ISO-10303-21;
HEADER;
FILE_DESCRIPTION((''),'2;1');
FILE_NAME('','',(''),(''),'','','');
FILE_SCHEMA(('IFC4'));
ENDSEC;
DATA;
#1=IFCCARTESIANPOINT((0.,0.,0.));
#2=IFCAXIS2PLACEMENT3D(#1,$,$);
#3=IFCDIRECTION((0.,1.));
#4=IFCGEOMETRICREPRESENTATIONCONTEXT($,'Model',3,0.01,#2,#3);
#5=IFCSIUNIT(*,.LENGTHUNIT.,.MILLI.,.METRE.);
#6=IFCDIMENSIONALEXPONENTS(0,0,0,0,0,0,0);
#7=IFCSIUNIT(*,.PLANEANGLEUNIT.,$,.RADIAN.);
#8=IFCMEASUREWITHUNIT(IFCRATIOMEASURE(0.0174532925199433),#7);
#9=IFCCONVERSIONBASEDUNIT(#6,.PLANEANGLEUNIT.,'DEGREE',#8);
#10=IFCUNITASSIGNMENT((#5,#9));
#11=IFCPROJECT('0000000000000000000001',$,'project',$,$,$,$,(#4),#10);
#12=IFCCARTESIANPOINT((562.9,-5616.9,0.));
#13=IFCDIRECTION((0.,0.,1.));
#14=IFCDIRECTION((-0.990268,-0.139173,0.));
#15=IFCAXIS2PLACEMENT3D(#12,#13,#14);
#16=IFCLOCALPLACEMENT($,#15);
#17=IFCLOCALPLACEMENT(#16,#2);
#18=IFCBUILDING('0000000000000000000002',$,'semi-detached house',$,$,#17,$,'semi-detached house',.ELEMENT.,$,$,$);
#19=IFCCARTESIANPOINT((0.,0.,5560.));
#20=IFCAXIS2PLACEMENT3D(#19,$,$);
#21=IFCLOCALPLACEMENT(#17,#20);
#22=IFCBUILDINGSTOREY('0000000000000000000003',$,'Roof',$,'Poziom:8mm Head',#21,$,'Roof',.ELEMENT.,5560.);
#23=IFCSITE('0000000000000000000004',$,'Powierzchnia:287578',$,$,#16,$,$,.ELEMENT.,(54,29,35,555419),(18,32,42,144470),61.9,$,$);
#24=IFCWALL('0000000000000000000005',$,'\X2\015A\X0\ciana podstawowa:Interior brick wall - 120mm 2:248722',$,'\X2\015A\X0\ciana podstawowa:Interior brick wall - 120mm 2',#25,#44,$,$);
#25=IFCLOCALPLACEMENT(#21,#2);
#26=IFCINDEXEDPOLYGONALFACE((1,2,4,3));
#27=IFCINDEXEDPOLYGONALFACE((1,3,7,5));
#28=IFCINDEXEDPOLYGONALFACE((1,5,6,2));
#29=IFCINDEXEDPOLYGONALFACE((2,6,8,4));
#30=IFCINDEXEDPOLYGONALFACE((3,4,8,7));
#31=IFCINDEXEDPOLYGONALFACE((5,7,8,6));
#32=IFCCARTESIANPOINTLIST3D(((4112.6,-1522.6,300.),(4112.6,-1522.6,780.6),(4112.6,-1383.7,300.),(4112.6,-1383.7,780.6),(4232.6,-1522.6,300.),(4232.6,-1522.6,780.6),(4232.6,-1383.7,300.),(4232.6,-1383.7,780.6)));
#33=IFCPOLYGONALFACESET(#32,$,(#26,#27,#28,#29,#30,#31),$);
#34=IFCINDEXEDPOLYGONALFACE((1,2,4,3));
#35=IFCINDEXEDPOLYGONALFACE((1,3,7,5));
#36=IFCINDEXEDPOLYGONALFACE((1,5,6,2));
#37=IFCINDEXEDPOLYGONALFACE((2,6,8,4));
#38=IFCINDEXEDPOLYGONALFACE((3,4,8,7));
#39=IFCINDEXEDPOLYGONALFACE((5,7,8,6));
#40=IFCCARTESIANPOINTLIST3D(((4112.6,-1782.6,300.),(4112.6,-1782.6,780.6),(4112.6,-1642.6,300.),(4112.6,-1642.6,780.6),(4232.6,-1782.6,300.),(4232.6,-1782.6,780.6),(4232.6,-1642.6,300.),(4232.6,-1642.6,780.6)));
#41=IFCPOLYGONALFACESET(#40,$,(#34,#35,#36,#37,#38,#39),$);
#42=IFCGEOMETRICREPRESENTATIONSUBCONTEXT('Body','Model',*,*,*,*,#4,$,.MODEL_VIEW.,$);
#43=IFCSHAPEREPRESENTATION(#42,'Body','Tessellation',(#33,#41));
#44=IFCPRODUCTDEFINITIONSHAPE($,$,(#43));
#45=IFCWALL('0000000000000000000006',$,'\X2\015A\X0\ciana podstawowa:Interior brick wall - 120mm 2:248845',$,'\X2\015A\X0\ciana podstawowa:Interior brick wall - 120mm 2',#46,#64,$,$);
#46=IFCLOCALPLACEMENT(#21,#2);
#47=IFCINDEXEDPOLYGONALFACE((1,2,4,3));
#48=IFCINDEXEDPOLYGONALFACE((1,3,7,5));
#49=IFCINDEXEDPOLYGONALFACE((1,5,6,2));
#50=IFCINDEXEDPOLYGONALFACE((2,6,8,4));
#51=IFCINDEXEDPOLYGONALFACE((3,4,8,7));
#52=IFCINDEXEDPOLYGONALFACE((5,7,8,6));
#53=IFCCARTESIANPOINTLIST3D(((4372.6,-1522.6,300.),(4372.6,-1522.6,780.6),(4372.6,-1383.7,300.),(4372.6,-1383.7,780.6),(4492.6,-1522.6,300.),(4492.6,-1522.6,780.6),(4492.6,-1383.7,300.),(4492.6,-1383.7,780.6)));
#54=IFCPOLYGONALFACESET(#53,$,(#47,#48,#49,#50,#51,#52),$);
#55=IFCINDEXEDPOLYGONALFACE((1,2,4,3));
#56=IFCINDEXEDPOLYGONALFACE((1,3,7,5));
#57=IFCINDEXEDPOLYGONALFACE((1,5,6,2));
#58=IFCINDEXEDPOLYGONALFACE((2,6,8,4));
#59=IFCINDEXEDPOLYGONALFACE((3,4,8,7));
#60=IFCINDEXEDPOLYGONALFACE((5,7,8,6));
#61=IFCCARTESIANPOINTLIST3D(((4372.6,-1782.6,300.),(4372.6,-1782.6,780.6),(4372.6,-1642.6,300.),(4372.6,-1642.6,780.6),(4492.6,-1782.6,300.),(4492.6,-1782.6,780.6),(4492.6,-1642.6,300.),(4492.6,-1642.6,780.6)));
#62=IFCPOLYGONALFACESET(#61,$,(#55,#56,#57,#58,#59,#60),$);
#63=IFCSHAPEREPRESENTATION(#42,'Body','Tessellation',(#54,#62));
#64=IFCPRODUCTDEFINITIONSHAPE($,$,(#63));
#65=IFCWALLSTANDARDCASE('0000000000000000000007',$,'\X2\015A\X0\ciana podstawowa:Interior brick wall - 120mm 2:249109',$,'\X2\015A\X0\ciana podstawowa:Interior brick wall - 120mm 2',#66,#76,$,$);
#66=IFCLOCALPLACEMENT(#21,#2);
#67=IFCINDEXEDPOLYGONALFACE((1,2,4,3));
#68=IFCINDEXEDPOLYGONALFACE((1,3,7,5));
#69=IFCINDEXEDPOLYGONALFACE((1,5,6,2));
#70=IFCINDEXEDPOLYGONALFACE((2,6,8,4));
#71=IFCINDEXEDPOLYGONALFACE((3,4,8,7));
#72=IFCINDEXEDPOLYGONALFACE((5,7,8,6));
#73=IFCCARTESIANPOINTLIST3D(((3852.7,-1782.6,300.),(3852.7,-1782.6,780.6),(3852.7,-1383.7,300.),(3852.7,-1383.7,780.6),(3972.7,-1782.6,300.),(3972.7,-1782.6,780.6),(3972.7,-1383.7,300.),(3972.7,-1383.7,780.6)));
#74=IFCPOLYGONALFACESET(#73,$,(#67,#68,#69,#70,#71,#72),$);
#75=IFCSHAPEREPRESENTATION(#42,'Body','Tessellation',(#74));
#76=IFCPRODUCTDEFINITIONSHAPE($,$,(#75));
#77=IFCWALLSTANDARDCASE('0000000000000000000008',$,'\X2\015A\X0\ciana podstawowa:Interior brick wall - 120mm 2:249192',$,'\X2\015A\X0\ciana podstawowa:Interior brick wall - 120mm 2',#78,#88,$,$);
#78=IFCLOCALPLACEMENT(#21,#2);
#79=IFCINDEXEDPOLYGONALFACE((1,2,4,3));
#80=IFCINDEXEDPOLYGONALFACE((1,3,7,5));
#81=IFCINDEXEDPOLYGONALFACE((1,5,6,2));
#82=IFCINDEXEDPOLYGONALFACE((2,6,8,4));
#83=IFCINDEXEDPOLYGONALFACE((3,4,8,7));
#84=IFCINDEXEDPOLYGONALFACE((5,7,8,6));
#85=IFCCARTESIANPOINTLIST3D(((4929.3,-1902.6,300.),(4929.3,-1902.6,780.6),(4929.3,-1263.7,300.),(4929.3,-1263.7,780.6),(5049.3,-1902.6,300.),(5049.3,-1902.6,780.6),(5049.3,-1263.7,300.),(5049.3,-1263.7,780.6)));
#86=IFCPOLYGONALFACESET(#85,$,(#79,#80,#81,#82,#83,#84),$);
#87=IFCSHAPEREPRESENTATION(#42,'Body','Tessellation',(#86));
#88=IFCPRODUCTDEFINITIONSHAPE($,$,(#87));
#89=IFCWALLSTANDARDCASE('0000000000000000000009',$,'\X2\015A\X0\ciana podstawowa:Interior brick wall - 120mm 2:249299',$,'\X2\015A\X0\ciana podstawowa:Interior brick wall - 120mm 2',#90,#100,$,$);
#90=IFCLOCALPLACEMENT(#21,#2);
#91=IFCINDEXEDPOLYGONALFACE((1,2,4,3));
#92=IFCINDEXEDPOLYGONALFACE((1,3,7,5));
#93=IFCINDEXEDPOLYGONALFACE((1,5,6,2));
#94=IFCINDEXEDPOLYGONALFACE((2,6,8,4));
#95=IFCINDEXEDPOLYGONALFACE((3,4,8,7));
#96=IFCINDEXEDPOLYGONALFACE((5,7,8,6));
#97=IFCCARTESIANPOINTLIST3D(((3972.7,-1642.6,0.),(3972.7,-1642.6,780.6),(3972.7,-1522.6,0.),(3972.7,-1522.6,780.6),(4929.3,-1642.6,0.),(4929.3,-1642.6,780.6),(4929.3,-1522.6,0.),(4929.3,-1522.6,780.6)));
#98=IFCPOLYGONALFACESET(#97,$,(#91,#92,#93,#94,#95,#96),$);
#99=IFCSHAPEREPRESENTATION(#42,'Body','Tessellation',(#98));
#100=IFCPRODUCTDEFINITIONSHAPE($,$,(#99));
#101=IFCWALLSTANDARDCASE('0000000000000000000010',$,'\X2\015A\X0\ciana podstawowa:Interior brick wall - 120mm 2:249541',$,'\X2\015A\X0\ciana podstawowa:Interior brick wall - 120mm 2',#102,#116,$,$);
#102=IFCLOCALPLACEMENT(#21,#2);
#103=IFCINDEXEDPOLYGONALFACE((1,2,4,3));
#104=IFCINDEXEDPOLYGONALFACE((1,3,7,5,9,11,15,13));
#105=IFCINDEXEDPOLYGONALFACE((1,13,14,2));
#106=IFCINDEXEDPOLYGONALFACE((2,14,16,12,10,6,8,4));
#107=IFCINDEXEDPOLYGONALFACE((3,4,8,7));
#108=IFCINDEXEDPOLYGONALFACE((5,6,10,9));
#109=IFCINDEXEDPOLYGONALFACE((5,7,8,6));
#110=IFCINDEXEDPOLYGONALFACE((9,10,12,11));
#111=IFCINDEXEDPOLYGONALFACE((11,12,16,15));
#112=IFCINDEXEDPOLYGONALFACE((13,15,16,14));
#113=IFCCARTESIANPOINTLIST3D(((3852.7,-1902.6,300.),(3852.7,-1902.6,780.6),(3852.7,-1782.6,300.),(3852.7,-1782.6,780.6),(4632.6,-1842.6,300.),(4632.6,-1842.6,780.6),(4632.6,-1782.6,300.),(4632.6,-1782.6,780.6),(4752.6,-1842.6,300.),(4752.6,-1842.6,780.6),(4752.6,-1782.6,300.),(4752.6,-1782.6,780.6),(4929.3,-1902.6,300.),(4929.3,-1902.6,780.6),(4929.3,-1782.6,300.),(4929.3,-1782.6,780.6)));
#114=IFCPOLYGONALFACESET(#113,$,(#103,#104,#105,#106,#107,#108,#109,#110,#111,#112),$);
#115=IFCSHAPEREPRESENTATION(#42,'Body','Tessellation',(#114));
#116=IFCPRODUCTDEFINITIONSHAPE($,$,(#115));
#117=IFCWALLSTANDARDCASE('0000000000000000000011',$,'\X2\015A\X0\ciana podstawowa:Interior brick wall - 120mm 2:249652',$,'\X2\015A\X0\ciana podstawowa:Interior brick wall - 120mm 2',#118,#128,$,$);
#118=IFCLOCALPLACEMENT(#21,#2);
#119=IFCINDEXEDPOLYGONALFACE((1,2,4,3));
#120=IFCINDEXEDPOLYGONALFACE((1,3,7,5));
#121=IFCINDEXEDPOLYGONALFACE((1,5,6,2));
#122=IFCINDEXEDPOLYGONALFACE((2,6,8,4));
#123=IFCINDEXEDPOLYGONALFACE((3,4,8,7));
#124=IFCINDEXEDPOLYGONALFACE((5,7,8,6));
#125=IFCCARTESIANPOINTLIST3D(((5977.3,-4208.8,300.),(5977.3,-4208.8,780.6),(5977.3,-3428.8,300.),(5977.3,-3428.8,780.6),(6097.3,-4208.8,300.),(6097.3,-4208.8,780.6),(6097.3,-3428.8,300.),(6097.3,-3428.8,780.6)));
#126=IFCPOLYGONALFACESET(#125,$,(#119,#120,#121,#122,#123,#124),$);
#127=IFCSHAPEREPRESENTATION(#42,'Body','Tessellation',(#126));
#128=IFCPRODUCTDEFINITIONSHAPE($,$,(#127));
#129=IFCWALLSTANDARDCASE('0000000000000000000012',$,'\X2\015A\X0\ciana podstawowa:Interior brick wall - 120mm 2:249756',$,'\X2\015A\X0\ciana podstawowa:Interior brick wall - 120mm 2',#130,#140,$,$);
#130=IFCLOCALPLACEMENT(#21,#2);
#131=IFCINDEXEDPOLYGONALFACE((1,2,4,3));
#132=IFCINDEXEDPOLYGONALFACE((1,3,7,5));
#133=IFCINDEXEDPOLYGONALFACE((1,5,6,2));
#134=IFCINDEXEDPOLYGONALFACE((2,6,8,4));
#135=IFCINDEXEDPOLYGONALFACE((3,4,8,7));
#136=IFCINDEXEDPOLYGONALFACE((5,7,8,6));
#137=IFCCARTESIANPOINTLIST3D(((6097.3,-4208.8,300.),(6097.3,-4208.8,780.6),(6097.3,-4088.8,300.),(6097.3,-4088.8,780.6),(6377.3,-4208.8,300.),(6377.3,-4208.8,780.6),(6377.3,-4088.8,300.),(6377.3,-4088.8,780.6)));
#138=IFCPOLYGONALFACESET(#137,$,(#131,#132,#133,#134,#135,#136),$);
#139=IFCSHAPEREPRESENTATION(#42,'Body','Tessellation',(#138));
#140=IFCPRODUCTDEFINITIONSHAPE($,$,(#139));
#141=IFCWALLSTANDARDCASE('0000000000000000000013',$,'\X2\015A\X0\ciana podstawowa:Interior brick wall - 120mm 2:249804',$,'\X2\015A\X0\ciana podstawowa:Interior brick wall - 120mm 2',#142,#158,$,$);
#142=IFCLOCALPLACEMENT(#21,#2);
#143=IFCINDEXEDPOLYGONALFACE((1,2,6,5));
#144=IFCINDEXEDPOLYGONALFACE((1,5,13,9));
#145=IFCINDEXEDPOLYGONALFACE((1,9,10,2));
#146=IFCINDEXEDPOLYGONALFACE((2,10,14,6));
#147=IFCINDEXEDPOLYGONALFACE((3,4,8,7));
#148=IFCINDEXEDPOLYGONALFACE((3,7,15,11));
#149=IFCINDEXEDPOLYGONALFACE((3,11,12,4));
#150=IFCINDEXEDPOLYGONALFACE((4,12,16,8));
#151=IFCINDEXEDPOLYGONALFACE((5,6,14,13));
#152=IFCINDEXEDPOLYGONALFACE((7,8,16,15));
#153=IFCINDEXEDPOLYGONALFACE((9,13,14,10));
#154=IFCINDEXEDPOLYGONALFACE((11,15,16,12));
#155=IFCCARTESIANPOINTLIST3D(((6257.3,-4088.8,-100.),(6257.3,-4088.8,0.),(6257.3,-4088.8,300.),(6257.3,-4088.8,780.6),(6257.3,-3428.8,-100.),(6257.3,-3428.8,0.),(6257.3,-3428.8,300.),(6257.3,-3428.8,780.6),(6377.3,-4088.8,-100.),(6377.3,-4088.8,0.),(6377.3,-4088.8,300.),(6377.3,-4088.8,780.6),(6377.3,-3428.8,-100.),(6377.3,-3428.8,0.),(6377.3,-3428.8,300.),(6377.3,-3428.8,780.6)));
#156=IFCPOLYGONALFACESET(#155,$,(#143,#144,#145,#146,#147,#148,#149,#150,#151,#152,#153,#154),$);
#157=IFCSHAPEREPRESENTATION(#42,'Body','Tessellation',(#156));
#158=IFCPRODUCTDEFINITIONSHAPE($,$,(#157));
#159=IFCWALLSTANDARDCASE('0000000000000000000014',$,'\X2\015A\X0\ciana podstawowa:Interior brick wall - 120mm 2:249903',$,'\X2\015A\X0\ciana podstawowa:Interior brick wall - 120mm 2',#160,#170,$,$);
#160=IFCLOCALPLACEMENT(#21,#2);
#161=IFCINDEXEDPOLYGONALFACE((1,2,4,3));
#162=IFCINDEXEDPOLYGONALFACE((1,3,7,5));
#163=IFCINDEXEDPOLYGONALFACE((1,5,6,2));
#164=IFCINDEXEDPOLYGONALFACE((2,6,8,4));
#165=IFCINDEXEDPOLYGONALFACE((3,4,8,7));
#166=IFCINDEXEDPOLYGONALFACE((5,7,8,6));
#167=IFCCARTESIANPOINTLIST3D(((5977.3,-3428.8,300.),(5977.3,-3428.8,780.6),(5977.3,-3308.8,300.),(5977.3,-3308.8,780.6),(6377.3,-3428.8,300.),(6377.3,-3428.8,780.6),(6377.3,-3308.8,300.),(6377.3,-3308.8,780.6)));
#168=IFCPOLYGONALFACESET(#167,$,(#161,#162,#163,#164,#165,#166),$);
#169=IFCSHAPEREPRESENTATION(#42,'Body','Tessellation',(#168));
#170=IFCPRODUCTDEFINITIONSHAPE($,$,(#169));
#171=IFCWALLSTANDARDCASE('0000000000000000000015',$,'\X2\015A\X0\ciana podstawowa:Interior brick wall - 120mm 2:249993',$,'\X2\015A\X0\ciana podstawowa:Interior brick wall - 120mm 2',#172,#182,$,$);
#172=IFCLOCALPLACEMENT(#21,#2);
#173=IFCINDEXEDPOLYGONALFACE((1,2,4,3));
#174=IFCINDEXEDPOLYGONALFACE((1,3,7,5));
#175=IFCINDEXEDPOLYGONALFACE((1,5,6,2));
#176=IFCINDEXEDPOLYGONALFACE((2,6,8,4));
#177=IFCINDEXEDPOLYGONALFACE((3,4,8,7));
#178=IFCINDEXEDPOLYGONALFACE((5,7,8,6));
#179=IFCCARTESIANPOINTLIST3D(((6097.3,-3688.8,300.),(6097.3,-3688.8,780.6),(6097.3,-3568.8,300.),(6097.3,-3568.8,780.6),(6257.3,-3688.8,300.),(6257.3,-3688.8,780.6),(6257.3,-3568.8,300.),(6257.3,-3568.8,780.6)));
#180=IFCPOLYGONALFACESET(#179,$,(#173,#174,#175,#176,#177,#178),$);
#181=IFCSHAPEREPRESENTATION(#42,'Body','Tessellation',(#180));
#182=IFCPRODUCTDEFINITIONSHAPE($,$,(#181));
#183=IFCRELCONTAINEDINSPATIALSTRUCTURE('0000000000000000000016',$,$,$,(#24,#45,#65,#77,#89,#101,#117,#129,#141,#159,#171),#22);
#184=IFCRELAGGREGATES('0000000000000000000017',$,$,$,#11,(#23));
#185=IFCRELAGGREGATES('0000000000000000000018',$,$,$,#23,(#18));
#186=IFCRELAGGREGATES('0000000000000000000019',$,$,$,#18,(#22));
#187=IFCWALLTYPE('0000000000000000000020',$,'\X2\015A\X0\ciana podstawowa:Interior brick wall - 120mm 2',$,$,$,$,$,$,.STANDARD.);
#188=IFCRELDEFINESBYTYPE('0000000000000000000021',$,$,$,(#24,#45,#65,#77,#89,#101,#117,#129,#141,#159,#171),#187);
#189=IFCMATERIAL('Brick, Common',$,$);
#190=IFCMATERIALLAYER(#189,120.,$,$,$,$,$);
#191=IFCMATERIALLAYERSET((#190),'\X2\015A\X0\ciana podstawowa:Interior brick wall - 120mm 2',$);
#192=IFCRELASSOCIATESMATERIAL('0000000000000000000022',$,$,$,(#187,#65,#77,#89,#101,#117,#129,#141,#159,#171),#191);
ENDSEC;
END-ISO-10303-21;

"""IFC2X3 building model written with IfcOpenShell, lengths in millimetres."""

from ifc_helpers import new_model, entity, si_unit, converted_unit, direction, frame, frame_2d, origin, place, context, subcontext, project, spatial, polyline, rectangle, extrude, clip, bounded_halfspace, material, layer, layer_set, layer_usage, type_object, element, save


model = new_model("IFC2X3")

# Units and contexts
model_context = context("Model", 3, precision=0.01, world=origin(), true_north=direction((0.0, 1.0)))
body_context = subcontext(model_context, "Body", "Model", "MODEL_VIEW")
ifc_project = project(units=[si_unit("LENGTHUNIT", "METRE", prefix="MILLI"), converted_unit("PLANEANGLEUNIT", "DEGREE", entity("IfcRatioMeasure", 0.0174532925199433), si_unit("PLANEANGLEUNIT", "RADIAN"), dimensions=[0, 0, 0, 0, 0, 0, 0])], contexts=[model_context])

# Site, building, storey
site_placement = place(None, frame((562.9, -5616.9, 0.0), z_axis=(0.0, 0.0, 1.0), x_axis=(-0.990268, -0.139173, 0.0)))
site = spatial("IfcSite", under=ifc_project, at=site_placement, Name="Powierzchnia:287578", CompositionType="ELEMENT", RefLatitude=(54, 29, 35, 555419), RefLongitude=(18, 32, 42, 144470), RefElevation=61.9)
building_placement = place(site_placement, origin())
building = spatial("IfcBuilding", under=site, at=building_placement, Name="semi-detached house", LongName="semi-detached house", CompositionType="ELEMENT")
storey_placement = place(building_placement, frame((0.0, 0.0, 5560.0)))
storey = spatial("IfcBuildingStorey", under=building, at=storey_placement, Name="Roof", ObjectType="Poziom:8mm Head", LongName="Roof", CompositionType="ELEMENT", Elevation=5560.0)

# Walls
ifc_material = material(Name="Brick, Common")
ifc_layer = layer(ifc_material, 120.0)
ifc_layer_set = layer_set([ifc_layer], Name="Ściana podstawowa:Interior brick wall - 120mm 2")
wall_type = type_object("IfcWallType", Name="Ściana podstawowa:Interior brick wall - 120mm 2", PredefinedType="STANDARD", material=ifc_layer_set)
wall_1_placement = place(storey_placement, frame((4172.6, -1383.7, 300.0), z_axis=(0.0, 0.0, 1.0), x_axis=(0.0, -1.0, 0.0)))
element("IfcWall", 1, at=wall_1_placement, inside=storey, type_object=wall_type, Name="Ściana podstawowa:Interior brick wall - 120mm 2:248722", ObjectType="Ściana podstawowa:Interior brick wall - 120mm 2", context=body_context, shape_type="SweptSolid", body=[
    extrude(rectangle(XDim=120.0, YDim=138.9, at=frame_2d((0.0, 0.0), x_axis=(1.0, 0.0))), frame((69.5, 0.0, 0.0), z_axis=(0.0, 0.0, 1.0), x_axis=(0.0, 1.0, 0.0)), (0.0, 0.0, 1.0), 480.6),
    extrude(rectangle(XDim=120.0, YDim=140.0, at=frame_2d((0.0, -23.0), x_axis=(1.0, 0.0))), frame((305.9, 0.0, 0.0), z_axis=(0.0, 0.0, 1.0), x_axis=(0.0, 1.0, 0.0)), (0.0, 0.0, 1.0), 480.6),
])
wall_2_placement = place(storey_placement, frame((4432.6, -1383.7, 300.0), z_axis=(0.0, 0.0, 1.0), x_axis=(0.0, -1.0, 0.0)))
element("IfcWall", 2, at=wall_2_placement, inside=storey, type_object=wall_type, Name="Ściana podstawowa:Interior brick wall - 120mm 2:248845", ObjectType="Ściana podstawowa:Interior brick wall - 120mm 2", context=body_context, shape_type="SweptSolid", body=[
    extrude(rectangle(XDim=120.0, YDim=138.9, at=frame_2d((0.0, 0.0), x_axis=(1.0, 0.0))), frame((69.5, 0.0, 0.0), z_axis=(0.0, 0.0, 1.0), x_axis=(0.0, 1.0, 0.0)), (0.0, 0.0, 1.0), 480.6),
    extrude(rectangle(XDim=120.0, YDim=140.0, at=frame_2d((0.0, -23.0), x_axis=(1.0, 0.0))), frame((305.9, 0.0, 0.0), z_axis=(0.0, 0.0, 1.0), x_axis=(0.0, 1.0, 0.0)), (0.0, 0.0, 1.0), 480.6),
])
ifc_layer_usage_1 = layer_usage(ifc_layer_set, "AXIS2", "NEGATIVE", 60.0)
wall_3_placement = place(storey_placement, frame((3912.7, -1383.7, 300.0), z_axis=(0.0, 0.0, 1.0), x_axis=(0.0, -1.0, 0.0)))
element("IfcWallStandardCase", 3, at=wall_3_placement, inside=storey, type_object=wall_type, material=ifc_layer_usage_1, Name="Ściana podstawowa:Interior brick wall - 120mm 2:249109", ObjectType="Ściana podstawowa:Interior brick wall - 120mm 2", context=body_context, shape_type="SweptSolid", body=[
    extrude(rectangle(XDim=120.0, YDim=398.9, at=frame_2d((-20.0, 0.0), x_axis=(1.0, 0.0))), frame((199.5, 20.0, 0.0), z_axis=(0.0, 0.0, 1.0), x_axis=(0.0, 1.0, 0.0)), (0.0, 0.0, 1.0), 480.6),
])
ifc_layer_usage_2 = layer_usage(ifc_layer_set, "AXIS2", "POSITIVE", -60.0)
wall_4_placement = place(storey_placement, frame((4989.3, -1263.7, 300.0), z_axis=(0.0, 0.0, 1.0), x_axis=(0.0, -1.0, 0.0)))
element("IfcWallStandardCase", 4, at=wall_4_placement, inside=storey, type_object=wall_type, material=ifc_layer_usage_2, Name="Ściana podstawowa:Interior brick wall - 120mm 2:249192", ObjectType="Ściana podstawowa:Interior brick wall - 120mm 2", context=body_context, shape_type="Clipping", body=[
    clip(extrude(rectangle(XDim=638.9, YDim=120.0, at=frame_2d((319.5, 0.0), x_axis=(-1.0, 0.0))), origin(), (0.0, 0.0, 1.0), 480.6), bounded_halfspace(frame((638.9, -60.0, 0.0), z_axis=(0.0, 0.0, 1.0), x_axis=(0.0, 1.0, 0.0)), True, frame((638.9, -60.0, 0.0), z_axis=(0.0, 0.0, 1.0), x_axis=(0.0, 1.0, 0.0)), polyline([(0.0, 0.0), (120.0, 0.0), (120.0, 638.9), (0.0, 638.9), (0.0, 518.9), (0.0, 120.0), (0.0, 0.0)]))),
])
ifc_layer_usage_3 = layer_usage(ifc_layer_set, "AXIS2", "POSITIVE", -60.0)
wall_5_placement = place(storey_placement, frame((4929.3, -1582.6, 0.0), z_axis=(0.0, 0.0, 1.0), x_axis=(-1.0, 0.0, 0.0)))
element("IfcWallStandardCase", 5, at=wall_5_placement, inside=storey, type_object=wall_type, material=ifc_layer_usage_3, Name="Ściana podstawowa:Interior brick wall - 120mm 2:249299", ObjectType="Ściana podstawowa:Interior brick wall - 120mm 2", context=body_context, shape_type="SweptSolid", body=[
    extrude(rectangle(XDim=956.6, YDim=120.0, at=frame_2d((478.3, 0.0), x_axis=(-1.0, 0.0))), origin(), (0.0, 0.0, 1.0), 780.6),
])
ifc_layer_usage_4 = layer_usage(ifc_layer_set, "AXIS2", "NEGATIVE", 60.0)
wall_6_placement = place(storey_placement, frame((3852.7, -1842.6, 300.0)))
element("IfcWallStandardCase", 6, at=wall_6_placement, inside=storey, type_object=wall_type, material=ifc_layer_usage_4, Name="Ściana podstawowa:Interior brick wall - 120mm 2:249541", ObjectType="Ściana podstawowa:Interior brick wall - 120mm 2", context=body_context, shape_type="Clipping", body=[
    clip(clip(extrude(rectangle(XDim=1076.6, YDim=120.0, at=frame_2d((538.3, 0.0), x_axis=(-1.0, 0.0))), origin(), (0.0, 0.0, 1.0), 480.6), bounded_halfspace(frame((1076.6, -60.0, 0.0)), True, frame((1076.6, -60.0, 0.0)), polyline([(0.0, 0.0), (0.0, 120.0), (-176.7, 120.0), (-176.7, 60.0), (-296.7, 60.0), (-296.7, 120.0), (-415.5, 120.0), (-436.7, 120.0), (-556.7, 120.0), (-675.5, 120.0), (-696.7, 120.0), (-816.7, 120.0), (-935.5, 120.0), (-956.7, 120.0), (-1076.6, 120.0), (-1076.6, 0.0), (0.0, 0.0)]))), bounded_halfspace(frame((779.9, 0.0, 0.0), z_axis=(0.0, -1.0, 0.0), x_axis=(1.0, 0.0, 0.0)), True, frame((779.9, 0.0, 0.0), z_axis=(0.0, -1.0, 0.0), x_axis=(1.0, 0.0, 0.0)), polyline([(0.0, 0.0), (120.0, 0.0), (120.0, 480.6), (0.0, 480.6), (0.0, 0.0)]))),
])
ifc_layer_usage_5 = layer_usage(ifc_layer_set, "AXIS2", "POSITIVE", -60.0)
wall_7_placement = place(storey_placement, frame((6037.3, -3428.8, 300.0), z_axis=(0.0, 0.0, 1.0), x_axis=(0.0, -1.0, 0.0)))
element("IfcWallStandardCase", 7, at=wall_7_placement, inside=storey, type_object=wall_type, material=ifc_layer_usage_5, Name="Ściana podstawowa:Interior brick wall - 120mm 2:249652", ObjectType="Ściana podstawowa:Interior brick wall - 120mm 2", context=body_context, shape_type="Clipping", body=[
    clip(extrude(rectangle(XDim=780.0, YDim=120.0, at=frame_2d((390.0, 0.0), x_axis=(-1.0, 0.0))), origin(), (0.0, 0.0, 1.0), 480.6), bounded_halfspace(frame((780.0, -60.0, 0.0), z_axis=(0.0, 0.0, 1.0), x_axis=(0.0, 1.0, 0.0)), True, frame((780.0, -60.0, 0.0), z_axis=(0.0, 0.0, 1.0), x_axis=(0.0, 1.0, 0.0)), polyline([(0.0, 0.0), (120.0, 0.0), (120.0, 120.0), (120.0, 260.0), (120.0, 380.0), (120.0, 520.0), (120.0, 640.0), (120.0, 780.0), (0.0, 780.0), (0.0, 0.0)]))),
])
ifc_layer_usage_6 = layer_usage(ifc_layer_set, "AXIS2", "POSITIVE", -60.0)
wall_8_placement = place(storey_placement, frame((6097.3, -4148.8, 300.0)))
element("IfcWallStandardCase", 8, at=wall_8_placement, inside=storey, type_object=wall_type, material=ifc_layer_usage_6, Name="Ściana podstawowa:Interior brick wall - 120mm 2:249756", ObjectType="Ściana podstawowa:Interior brick wall - 120mm 2", context=body_context, shape_type="SweptSolid", body=[
    extrude(rectangle(XDim=280.0, YDim=120.0, at=frame_2d((140.0, 0.0), x_axis=(-1.0, 0.0))), origin(), (0.0, 0.0, 1.0), 480.6),
])

# Wall, opening
ifc_layer_usage_7 = layer_usage(ifc_layer_set, "AXIS2", "POSITIVE", -60.0)
wall_9_placement = place(storey_placement, frame((6317.3, -4088.8, -100.0), z_axis=(0.0, 0.0, 1.0), x_axis=(0.0, 1.0, 0.0)))
wall_9 = element("IfcWallStandardCase", 9, at=wall_9_placement, inside=storey, type_object=wall_type, material=ifc_layer_usage_7, Name="Ściana podstawowa:Interior brick wall - 120mm 2:249804", ObjectType="Ściana podstawowa:Interior brick wall - 120mm 2", context=body_context, shape_type="SweptSolid", body=[
    extrude(rectangle(XDim=660.0, YDim=120.0, at=frame_2d((330.0, 0.0), x_axis=(-1.0, 0.0))), origin(), (0.0, 0.0, 1.0), 880.6),
])
opening_1_placement = place(storey_placement, frame((6317.3, -4088.8, -100.0), z_axis=(0.0, 0.0, 1.0), x_axis=(0.0, 1.0, 0.0)))
element("IfcOpeningElement", 10, at=opening_1_placement, cuts=wall_9, ObjectType="Opening", context=body_context, shape_type="SweptSolid", body=[
    extrude(rectangle(XDim=660.0, YDim=120.0, at=frame_2d((0.0, -30.0), x_axis=(1.0, 0.0))), frame((330.0, 30.0, 100.0)), (0.0, 0.0, 1.0), 300.0),
])

# Walls
ifc_layer_usage_8 = layer_usage(ifc_layer_set, "AXIS2", "NEGATIVE", 60.0)
wall_10_placement = place(storey_placement, frame((6377.3, -3368.8, 300.0), z_axis=(0.0, 0.0, 1.0), x_axis=(-1.0, 0.0, 0.0)))
element("IfcWallStandardCase", 11, at=wall_10_placement, inside=storey, type_object=wall_type, material=ifc_layer_usage_8, Name="Ściana podstawowa:Interior brick wall - 120mm 2:249903", ObjectType="Ściana podstawowa:Interior brick wall - 120mm 2", context=body_context, shape_type="SweptSolid", body=[
    extrude(rectangle(XDim=400.0, YDim=120.0, at=frame_2d((200.0, 0.0), x_axis=(-1.0, 0.0))), origin(), (0.0, 0.0, 1.0), 480.6),
])
ifc_layer_usage_9 = layer_usage(ifc_layer_set, "AXIS2", "NEGATIVE", 60.0)
wall_11_placement = place(storey_placement, frame((6097.3, -3628.8, 300.0)))
element("IfcWallStandardCase", 12, at=wall_11_placement, inside=storey, type_object=wall_type, material=ifc_layer_usage_9, Name="Ściana podstawowa:Interior brick wall - 120mm 2:249993", ObjectType="Ściana podstawowa:Interior brick wall - 120mm 2", context=body_context, shape_type="SweptSolid", body=[
    extrude(rectangle(XDim=160.0, YDim=120.0, at=frame_2d((80.0, 0.0), x_axis=(-1.0, 0.0))), origin(), (0.0, 0.0, 1.0), 480.6),
])

save(model, "model.ifc")
